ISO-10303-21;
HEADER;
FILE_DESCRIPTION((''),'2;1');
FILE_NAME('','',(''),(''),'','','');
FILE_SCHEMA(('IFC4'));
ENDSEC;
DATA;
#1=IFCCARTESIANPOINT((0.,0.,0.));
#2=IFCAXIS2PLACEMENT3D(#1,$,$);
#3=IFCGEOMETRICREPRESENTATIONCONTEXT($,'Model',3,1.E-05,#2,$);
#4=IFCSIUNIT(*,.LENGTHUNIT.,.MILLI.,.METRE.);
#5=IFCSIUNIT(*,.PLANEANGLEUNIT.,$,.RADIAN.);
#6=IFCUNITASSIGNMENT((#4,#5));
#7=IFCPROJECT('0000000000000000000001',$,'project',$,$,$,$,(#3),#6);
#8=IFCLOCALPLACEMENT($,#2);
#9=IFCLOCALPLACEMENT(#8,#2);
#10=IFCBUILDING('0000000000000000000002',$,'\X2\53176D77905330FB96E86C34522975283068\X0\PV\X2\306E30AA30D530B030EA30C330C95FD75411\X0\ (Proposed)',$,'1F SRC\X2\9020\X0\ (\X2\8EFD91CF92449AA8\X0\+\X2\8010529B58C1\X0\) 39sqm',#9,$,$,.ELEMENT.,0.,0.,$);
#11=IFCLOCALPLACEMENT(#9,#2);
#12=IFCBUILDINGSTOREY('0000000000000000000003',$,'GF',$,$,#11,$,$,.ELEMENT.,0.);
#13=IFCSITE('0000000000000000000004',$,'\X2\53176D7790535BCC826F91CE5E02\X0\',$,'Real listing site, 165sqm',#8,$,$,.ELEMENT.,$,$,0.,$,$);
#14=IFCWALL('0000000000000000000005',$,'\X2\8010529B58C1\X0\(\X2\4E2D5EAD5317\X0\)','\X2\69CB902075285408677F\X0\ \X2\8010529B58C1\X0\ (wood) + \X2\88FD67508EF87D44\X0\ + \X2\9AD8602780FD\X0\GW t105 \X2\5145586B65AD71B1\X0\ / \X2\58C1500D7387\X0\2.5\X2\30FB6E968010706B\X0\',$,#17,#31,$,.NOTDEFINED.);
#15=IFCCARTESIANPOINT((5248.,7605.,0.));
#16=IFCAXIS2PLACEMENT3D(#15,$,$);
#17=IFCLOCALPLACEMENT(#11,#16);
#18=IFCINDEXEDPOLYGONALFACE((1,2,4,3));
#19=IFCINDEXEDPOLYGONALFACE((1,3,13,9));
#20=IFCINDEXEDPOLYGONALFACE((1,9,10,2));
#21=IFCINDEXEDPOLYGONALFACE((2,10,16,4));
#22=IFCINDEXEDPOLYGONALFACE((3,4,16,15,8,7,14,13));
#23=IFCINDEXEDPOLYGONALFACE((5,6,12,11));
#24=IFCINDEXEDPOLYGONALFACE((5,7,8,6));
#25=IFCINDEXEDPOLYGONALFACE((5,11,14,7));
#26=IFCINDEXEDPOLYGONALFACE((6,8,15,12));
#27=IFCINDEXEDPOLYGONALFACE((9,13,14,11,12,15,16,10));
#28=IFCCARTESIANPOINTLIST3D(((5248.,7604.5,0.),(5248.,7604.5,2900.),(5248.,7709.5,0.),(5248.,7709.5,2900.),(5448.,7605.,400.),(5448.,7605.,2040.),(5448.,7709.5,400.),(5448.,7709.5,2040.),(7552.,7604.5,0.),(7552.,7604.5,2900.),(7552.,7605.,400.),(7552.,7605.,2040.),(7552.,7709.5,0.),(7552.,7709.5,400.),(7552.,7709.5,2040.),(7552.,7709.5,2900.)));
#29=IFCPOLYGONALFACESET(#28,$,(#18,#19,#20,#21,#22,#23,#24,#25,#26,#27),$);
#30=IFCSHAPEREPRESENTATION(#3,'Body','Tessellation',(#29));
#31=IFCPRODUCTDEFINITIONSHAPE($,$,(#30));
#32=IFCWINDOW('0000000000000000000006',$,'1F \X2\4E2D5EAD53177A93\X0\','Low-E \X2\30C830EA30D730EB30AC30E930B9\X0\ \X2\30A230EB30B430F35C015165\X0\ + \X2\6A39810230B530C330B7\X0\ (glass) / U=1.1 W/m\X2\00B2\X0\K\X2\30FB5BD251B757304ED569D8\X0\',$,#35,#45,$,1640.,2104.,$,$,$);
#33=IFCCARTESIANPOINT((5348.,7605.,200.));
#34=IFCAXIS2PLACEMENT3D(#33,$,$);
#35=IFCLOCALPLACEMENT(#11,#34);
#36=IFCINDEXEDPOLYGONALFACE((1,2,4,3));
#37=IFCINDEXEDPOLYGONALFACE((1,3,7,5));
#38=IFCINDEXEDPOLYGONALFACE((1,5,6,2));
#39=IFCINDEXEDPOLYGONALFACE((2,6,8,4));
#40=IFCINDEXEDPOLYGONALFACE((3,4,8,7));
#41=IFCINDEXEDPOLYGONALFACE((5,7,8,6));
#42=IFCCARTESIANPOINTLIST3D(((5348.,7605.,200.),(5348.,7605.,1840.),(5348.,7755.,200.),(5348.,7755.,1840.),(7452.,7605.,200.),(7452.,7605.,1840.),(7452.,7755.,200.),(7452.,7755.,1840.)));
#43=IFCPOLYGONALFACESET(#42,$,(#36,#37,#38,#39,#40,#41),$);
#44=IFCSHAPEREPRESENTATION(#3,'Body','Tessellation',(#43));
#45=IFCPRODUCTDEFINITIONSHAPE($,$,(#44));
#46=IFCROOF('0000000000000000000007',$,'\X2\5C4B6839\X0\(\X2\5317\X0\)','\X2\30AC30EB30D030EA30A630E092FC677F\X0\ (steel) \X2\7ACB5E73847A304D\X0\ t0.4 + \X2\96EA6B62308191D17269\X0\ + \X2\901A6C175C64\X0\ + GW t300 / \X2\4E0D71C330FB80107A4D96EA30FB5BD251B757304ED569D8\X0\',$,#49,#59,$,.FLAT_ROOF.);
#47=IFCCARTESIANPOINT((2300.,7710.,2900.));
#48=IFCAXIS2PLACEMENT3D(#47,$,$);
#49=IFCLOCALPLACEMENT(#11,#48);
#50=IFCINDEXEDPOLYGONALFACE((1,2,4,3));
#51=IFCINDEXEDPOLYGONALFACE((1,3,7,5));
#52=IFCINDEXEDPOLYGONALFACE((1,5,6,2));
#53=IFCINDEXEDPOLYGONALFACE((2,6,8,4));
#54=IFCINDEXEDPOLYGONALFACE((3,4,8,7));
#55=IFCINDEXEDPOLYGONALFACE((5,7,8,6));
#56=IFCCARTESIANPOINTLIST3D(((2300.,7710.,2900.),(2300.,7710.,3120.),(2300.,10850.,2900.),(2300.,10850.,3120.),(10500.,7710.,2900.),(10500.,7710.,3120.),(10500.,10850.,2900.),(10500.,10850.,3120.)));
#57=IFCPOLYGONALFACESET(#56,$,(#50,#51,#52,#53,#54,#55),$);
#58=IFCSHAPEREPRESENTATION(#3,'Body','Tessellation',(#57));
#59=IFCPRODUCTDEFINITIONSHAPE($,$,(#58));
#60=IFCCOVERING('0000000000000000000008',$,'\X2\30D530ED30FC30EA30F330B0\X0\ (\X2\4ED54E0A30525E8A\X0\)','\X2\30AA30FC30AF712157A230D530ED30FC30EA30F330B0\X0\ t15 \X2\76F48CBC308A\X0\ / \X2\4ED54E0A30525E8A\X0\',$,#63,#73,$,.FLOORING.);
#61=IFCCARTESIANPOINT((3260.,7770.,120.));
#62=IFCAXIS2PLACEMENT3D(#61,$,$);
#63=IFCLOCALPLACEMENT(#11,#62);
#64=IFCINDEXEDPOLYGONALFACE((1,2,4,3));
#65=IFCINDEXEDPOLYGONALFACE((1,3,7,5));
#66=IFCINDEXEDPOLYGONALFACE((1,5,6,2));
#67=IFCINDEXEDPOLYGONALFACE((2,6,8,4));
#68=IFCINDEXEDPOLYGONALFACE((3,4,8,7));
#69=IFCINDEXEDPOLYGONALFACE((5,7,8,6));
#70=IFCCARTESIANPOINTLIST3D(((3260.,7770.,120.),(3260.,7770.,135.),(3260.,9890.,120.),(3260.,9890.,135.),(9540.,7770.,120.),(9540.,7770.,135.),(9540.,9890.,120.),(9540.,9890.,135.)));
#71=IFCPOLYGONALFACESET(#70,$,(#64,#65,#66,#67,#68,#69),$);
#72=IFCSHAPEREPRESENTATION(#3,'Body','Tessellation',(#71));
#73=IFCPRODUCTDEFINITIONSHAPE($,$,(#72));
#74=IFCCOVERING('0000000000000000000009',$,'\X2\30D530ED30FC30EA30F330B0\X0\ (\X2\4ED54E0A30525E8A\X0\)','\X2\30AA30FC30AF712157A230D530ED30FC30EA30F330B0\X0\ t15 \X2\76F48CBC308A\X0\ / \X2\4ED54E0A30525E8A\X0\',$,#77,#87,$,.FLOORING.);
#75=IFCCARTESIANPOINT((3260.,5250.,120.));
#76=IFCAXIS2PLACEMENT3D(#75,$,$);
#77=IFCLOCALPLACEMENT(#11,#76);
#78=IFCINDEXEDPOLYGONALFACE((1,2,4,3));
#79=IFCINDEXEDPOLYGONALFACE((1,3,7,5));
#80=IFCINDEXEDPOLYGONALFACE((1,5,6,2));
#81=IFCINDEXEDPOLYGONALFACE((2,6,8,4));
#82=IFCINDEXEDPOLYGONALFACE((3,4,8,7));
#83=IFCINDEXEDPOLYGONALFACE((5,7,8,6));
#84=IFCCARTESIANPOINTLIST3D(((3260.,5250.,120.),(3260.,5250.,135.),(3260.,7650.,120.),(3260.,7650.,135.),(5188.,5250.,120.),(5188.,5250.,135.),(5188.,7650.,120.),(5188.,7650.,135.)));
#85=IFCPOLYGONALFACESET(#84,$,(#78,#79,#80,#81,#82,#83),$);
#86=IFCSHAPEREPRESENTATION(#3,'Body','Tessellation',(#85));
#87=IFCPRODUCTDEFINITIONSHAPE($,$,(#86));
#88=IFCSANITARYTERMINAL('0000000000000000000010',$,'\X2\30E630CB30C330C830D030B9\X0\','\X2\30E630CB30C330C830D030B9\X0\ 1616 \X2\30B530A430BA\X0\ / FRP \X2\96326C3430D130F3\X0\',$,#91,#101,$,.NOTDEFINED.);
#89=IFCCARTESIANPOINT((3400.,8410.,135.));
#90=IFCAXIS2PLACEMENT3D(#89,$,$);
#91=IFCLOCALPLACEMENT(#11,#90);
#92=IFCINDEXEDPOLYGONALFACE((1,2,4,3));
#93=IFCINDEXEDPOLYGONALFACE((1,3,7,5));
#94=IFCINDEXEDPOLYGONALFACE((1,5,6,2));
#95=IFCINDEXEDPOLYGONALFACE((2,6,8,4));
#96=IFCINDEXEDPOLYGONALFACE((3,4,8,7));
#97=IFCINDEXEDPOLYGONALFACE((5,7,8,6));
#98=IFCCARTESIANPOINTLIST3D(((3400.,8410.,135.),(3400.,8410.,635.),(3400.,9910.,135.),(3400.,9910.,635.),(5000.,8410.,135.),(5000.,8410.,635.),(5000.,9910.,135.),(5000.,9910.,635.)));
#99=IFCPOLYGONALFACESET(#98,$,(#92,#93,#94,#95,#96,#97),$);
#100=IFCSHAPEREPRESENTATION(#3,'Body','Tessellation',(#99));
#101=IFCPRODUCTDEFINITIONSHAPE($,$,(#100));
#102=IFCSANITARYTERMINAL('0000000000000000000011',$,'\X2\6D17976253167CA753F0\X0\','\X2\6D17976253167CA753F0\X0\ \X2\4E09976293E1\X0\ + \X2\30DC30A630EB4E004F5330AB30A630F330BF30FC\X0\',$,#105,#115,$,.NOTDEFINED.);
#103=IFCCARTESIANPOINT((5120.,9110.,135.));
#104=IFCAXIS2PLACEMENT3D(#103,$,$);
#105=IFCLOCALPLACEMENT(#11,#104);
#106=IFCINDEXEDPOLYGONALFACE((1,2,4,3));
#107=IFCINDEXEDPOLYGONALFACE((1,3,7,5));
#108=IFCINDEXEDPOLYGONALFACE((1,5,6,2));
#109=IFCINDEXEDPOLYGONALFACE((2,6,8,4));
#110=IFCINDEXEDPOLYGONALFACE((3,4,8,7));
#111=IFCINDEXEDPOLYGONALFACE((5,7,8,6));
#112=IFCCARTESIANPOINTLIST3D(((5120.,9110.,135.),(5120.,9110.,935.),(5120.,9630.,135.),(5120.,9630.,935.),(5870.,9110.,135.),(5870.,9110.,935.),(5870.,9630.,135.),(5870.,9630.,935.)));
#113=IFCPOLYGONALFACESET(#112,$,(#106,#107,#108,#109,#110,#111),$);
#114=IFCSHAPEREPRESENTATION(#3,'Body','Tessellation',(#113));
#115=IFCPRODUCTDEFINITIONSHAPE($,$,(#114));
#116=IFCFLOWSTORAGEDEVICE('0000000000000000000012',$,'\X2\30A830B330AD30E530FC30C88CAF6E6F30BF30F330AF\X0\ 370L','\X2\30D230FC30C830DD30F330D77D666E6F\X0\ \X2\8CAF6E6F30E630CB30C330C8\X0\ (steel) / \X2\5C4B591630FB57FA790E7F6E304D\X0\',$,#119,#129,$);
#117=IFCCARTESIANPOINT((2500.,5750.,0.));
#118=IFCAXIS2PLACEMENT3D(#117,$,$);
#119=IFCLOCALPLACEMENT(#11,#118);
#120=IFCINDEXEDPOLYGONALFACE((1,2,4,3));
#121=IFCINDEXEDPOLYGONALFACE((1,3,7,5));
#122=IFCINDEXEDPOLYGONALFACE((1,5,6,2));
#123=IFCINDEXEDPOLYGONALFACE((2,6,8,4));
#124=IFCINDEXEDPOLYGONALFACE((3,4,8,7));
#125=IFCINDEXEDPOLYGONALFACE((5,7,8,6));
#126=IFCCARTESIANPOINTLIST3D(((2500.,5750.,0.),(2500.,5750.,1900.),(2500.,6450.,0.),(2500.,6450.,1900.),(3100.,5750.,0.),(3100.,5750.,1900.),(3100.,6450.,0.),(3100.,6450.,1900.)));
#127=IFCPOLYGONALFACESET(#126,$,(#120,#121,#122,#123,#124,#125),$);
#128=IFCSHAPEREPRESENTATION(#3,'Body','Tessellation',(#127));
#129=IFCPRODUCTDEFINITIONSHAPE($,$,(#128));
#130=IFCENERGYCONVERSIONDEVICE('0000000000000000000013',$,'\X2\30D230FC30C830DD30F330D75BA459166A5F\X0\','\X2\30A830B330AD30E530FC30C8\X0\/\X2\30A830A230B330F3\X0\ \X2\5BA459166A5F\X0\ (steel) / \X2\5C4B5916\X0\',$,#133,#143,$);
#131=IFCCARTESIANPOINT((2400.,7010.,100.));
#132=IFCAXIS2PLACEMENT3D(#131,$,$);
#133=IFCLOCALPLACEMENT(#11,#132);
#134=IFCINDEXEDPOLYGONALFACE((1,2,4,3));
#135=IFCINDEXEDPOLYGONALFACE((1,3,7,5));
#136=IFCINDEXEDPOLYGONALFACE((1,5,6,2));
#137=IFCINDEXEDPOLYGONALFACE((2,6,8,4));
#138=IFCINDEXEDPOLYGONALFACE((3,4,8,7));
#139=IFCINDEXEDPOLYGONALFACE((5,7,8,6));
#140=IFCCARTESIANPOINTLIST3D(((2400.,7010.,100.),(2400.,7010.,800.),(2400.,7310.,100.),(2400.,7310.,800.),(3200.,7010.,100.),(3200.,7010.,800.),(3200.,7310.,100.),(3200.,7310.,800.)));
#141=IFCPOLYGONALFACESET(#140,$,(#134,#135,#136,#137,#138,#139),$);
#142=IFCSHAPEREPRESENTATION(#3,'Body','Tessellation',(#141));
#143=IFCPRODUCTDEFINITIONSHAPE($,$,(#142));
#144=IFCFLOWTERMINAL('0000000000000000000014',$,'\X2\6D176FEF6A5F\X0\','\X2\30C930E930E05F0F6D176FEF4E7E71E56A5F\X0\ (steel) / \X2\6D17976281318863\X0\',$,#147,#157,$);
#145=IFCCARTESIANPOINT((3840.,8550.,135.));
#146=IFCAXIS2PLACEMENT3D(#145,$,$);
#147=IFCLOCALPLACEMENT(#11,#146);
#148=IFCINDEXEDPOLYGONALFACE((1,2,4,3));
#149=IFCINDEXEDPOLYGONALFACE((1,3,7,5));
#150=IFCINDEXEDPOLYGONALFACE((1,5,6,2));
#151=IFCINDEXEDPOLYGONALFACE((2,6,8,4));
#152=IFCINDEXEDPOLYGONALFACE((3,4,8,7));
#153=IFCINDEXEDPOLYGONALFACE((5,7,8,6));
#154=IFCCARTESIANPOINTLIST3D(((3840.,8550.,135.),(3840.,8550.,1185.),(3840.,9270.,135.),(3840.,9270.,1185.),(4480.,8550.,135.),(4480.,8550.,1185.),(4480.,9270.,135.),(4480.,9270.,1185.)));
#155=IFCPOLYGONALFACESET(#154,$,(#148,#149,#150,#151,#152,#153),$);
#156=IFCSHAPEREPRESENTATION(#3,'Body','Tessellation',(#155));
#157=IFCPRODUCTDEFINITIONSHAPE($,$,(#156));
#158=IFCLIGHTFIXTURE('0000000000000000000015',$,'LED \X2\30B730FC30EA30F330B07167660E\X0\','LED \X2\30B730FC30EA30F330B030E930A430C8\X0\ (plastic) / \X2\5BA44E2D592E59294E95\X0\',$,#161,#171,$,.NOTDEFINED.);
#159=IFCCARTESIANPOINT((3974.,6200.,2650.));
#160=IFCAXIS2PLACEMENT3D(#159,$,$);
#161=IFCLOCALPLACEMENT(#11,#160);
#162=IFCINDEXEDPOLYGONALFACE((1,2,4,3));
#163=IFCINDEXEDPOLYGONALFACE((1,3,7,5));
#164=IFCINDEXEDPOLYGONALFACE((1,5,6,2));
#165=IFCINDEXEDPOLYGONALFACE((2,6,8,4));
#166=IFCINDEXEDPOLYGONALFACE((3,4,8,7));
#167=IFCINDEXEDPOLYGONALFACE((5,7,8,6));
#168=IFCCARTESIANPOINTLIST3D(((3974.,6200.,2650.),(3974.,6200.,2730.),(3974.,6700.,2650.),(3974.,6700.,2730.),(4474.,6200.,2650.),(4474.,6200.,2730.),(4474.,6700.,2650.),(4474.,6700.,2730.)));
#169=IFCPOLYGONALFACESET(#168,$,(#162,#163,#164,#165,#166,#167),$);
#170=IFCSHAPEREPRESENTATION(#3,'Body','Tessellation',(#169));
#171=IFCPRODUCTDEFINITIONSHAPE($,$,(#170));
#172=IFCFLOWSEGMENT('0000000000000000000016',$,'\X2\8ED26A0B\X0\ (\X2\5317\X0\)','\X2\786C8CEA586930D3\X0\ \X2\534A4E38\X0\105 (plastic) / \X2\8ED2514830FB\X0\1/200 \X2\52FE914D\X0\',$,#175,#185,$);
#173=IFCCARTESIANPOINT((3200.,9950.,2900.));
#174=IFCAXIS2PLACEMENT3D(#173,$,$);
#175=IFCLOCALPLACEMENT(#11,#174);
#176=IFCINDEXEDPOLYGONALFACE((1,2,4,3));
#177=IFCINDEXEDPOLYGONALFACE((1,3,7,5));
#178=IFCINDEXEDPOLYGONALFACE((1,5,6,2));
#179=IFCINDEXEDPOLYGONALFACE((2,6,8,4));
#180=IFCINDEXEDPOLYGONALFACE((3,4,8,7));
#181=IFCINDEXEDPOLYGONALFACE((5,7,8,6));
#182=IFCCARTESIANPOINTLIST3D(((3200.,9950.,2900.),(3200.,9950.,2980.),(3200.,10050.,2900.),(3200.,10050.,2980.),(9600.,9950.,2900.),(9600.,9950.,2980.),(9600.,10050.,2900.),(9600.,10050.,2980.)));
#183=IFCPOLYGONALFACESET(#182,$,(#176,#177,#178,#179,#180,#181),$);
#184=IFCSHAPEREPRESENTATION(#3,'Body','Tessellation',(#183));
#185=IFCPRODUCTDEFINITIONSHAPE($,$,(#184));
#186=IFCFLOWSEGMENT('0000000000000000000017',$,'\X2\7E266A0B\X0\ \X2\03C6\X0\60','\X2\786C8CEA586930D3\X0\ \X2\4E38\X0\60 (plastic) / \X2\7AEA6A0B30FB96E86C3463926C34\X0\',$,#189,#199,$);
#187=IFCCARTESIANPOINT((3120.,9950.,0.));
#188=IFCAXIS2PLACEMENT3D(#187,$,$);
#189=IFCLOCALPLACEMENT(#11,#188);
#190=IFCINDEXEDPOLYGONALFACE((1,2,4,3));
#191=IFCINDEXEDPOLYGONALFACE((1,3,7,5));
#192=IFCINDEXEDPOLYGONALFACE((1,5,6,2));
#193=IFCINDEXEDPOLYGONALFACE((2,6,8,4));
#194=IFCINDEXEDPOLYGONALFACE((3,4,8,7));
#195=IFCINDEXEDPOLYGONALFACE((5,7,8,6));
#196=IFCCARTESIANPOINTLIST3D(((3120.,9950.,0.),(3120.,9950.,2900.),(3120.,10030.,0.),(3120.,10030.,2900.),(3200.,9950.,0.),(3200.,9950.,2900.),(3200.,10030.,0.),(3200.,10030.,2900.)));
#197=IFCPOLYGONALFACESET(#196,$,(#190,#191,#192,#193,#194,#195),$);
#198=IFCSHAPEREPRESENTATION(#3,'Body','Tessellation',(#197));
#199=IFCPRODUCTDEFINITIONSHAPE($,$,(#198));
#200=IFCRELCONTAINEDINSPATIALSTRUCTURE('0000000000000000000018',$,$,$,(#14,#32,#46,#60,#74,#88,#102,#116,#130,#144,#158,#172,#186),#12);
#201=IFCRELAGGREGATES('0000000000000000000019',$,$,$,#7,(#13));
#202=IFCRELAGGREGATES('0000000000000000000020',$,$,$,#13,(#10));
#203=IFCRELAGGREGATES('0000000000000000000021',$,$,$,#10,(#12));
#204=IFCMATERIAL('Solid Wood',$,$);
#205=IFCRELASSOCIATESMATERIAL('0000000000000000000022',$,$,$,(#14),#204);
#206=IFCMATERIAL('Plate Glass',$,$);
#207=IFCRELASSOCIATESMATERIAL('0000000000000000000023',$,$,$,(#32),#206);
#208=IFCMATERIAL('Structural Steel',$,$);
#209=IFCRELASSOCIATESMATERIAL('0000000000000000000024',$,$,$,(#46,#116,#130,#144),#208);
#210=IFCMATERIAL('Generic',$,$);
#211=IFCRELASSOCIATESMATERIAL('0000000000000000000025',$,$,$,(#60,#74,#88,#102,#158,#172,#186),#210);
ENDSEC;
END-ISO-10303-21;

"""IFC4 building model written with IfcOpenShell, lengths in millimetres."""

from ifc_helpers import new_model, si_unit, frame, frame_2d, origin, place, context, project, spatial, rectangle, extrude, material, element, fill, save


model = new_model("IFC4")

# Units and contexts
model_context = context("Model", 3, precision=1e-05, world=origin())
ifc_project = project(units=[si_unit("LENGTHUNIT", "METRE", prefix="MILLI"), si_unit("PLANEANGLEUNIT", "RADIAN")], contexts=[model_context])

# Site, building, storey
site_placement = place(None, origin())
site = spatial("IfcSite", under=ifc_project, at=site_placement, Name="北海道富良野市", ObjectType="Real listing site, 165sqm", CompositionType="ELEMENT", RefElevation=0.0)
building_placement = place(site_placement, origin())
building = spatial("IfcBuilding", under=site, at=building_placement, Name="北海道・雨水利用とPVのオフグリッド志向 (Proposed)", ObjectType="1F SRC造 (軽量鉄骨+耐力壁) 39sqm", CompositionType="ELEMENT", ElevationOfRefHeight=0.0, ElevationOfTerrain=0.0)
storey_placement = place(building_placement, origin())
storey = spatial("IfcBuildingStorey", under=building, at=storey_placement, Name="GF", CompositionType="ELEMENT", Elevation=0.0)

# Shared definitions
ifc_material_1 = material(Name="Solid Wood")

# Shared definitions
ifc_material_2 = material(Name="Plate Glass")

# Wall, opening, window
wall_1_placement = place(storey_placement, frame((5248.0, 7605.0, 0.0)))
wall_1 = element("IfcWall", 1, at=wall_1_placement, inside=storey, material=ifc_material_1, Name="耐力壁(中庭北)", Description="構造用合板 耐力壁 (wood) + 製材軸組 + 高性能GW t105 充填断熱 / 壁倍率2.5・準耐火", PredefinedType="NOTDEFINED", context=model_context, shape_type="SweptSolid", body=[
    extrude(rectangle(XDim=2304.0, YDim=105.0, at=frame_2d((1152.0, 52.0))), frame((5248.0, 7605.0, 0.0)), (0.0, 0.0, 1.0), 2900.0),
])
opening_1_placement = place(storey_placement, frame((5348.0, 7605.0, 200.0)))
opening_1 = element("IfcOpeningElement", 2, at=opening_1_placement, cuts=wall_1, PredefinedType="NOTDEFINED", context=model_context, shape_type="SweptSolid", body=[
    extrude(rectangle(XDim=2104.0, YDim=150.0, at=frame_2d((1052.0, 75.0))), frame((5348.0, 7605.0, 200.0)), (0.0, 0.0, 1.0), 1640.0),
])
window_1_placement = place(storey_placement, frame((5348.0, 7605.0, 200.0)))
window_1 = element("IfcWindow", 3, at=window_1_placement, inside=storey, material=ifc_material_2, Name="1F 中庭北窓", Description="Low-E トリプルガラス アルゴン封入 + 樹脂サッシ (glass) / U=1.1 W/m²K・寒冷地仕様", OverallHeight=1640.0, OverallWidth=2104.0, context=model_context, shape_type="SweptSolid", body=[
    extrude(rectangle(XDim=2104.0, YDim=150.0, at=frame_2d((1052.0, 75.0))), frame((5348.0, 7605.0, 200.0)), (0.0, 0.0, 1.0), 1640.0),
])
fill(opening_1, window_1)

# Roof
ifc_material_3 = material(Name="Structural Steel")
roof_placement = place(storey_placement, frame((2300.0, 7710.0, 2900.0)))
element("IfcRoof", 4, at=roof_placement, inside=storey, material=ifc_material_3, Name="屋根(北)", Description="ガルバリウム鋼板 (steel) 立平葺き t0.4 + 雪止め金物 + 通気層 + GW t300 / 不燃・耐積雪・寒冷地仕様", PredefinedType="FLAT_ROOF", context=model_context, shape_type="SweptSolid", body=[
    extrude(rectangle(XDim=8200.0, YDim=3140.0, at=frame_2d((4100.0, 1570.0))), frame((2300.0, 7710.0, 2900.0)), (0.0, 0.0, 1.0), 220.0),
])

# Coverings
ifc_material_4 = material(Name="Generic")
covering_1_placement = place(storey_placement, frame((3260.0, 7770.0, 120.0)))
element("IfcCovering", 5, at=covering_1_placement, inside=storey, material=ifc_material_4, Name="フローリング (仕上げ床)", Description="オーク無垢フローリング t15 直貼り / 仕上げ床", PredefinedType="FLOORING", context=model_context, shape_type="SweptSolid", body=[
    extrude(rectangle(XDim=6280.0, YDim=2120.0, at=frame_2d((3140.0, 1060.0))), frame((3260.0, 7770.0, 120.0)), (0.0, 0.0, 1.0), 15.0),
])
covering_2_placement = place(storey_placement, frame((3260.0, 5250.0, 120.0)))
element("IfcCovering", 6, at=covering_2_placement, inside=storey, material=ifc_material_4, Name="フローリング (仕上げ床)", Description="オーク無垢フローリング t15 直貼り / 仕上げ床", PredefinedType="FLOORING", context=model_context, shape_type="SweptSolid", body=[
    extrude(rectangle(XDim=1928.0, YDim=2400.0, at=frame_2d((964.0, 1200.0))), frame((3260.0, 5250.0, 120.0)), (0.0, 0.0, 1.0), 15.0),
])

# Sanitary terminals
sanitary_terminal_1_placement = place(storey_placement, frame((3400.0, 8410.0, 135.0)))
element("IfcSanitaryTerminal", 7, at=sanitary_terminal_1_placement, inside=storey, material=ifc_material_4, Name="ユニットバス", Description="ユニットバス 1616 サイズ / FRP 防水パン", PredefinedType="NOTDEFINED", context=model_context, shape_type="SweptSolid", body=[
    extrude(rectangle(XDim=1600.0, YDim=1500.0, at=frame_2d((800.0, 750.0))), frame((3400.0, 8410.0, 135.0)), (0.0, 0.0, 1.0), 500.0),
])
sanitary_terminal_2_placement = place(storey_placement, frame((5120.0, 9110.0, 135.0)))
element("IfcSanitaryTerminal", 8, at=sanitary_terminal_2_placement, inside=storey, material=ifc_material_4, Name="洗面化粧台", Description="洗面化粧台 三面鏡 + ボウル一体カウンター", PredefinedType="NOTDEFINED", context=model_context, shape_type="SweptSolid", body=[
    extrude(rectangle(XDim=750.0, YDim=520.0, at=frame_2d((375.0, 260.0))), frame((5120.0, 9110.0, 135.0)), (0.0, 0.0, 1.0), 800.0),
])

# Flow storage device
flow_storage_device_placement = place(storey_placement, frame((2500.0, 5750.0, 0.0)))
element("IfcFlowStorageDevice", 9, at=flow_storage_device_placement, inside=storey, material=ifc_material_3, Name="エコキュート貯湯タンク 370L", Description="ヒートポンプ給湯 貯湯ユニット (steel) / 屋外・基礎置き", context=model_context, shape_type="SweptSolid", body=[
    extrude(rectangle(XDim=600.0, YDim=700.0, at=frame_2d((300.0, 350.0))), frame((2500.0, 5750.0, 0.0)), (0.0, 0.0, 1.0), 1900.0),
])

# Energy conversion device
energy_conversion_device_placement = place(storey_placement, frame((2400.0, 7010.0, 100.0)))
element("IfcEnergyConversionDevice", 10, at=energy_conversion_device_placement, inside=storey, material=ifc_material_3, Name="ヒートポンプ室外機", Description="エコキュート/エアコン 室外機 (steel) / 屋外", context=model_context, shape_type="SweptSolid", body=[
    extrude(rectangle(XDim=800.0, YDim=300.0, at=frame_2d((400.0, 150.0))), frame((2400.0, 7010.0, 100.0)), (0.0, 0.0, 1.0), 700.0),
])

# Flow terminal
flow_terminal_placement = place(storey_placement, frame((3840.0, 8550.0, 135.0)))
element("IfcFlowTerminal", 11, at=flow_terminal_placement, inside=storey, material=ifc_material_3, Name="洗濯機", Description="ドラム式洗濯乾燥機 (steel) / 洗面脱衣", context=model_context, shape_type="SweptSolid", body=[
    extrude(rectangle(XDim=640.0, YDim=720.0, at=frame_2d((320.0, 360.0))), frame((3840.0, 8550.0, 135.0)), (0.0, 0.0, 1.0), 1050.0),
])

# Light fixture
light_fixture_placement = place(storey_placement, frame((3974.0, 6200.0, 2650.0)))
element("IfcLightFixture", 12, at=light_fixture_placement, inside=storey, material=ifc_material_4, Name="LED シーリング照明", Description="LED シーリングライト (plastic) / 室中央天井", PredefinedType="NOTDEFINED", context=model_context, shape_type="SweptSolid", body=[
    extrude(rectangle(XDim=500.0, YDim=500.0, at=frame_2d((250.0, 250.0))), frame((3974.0, 6200.0, 2650.0)), (0.0, 0.0, 1.0), 80.0),
])

# Flow segments
flow_segment_1_placement = place(storey_placement, frame((3200.0, 9950.0, 2900.0)))
element("IfcFlowSegment", 13, at=flow_segment_1_placement, inside=storey, material=ifc_material_4, Name="軒樋 (北)", Description="硬質塩ビ 半丸105 (plastic) / 軒先・1/200 勾配", context=model_context, shape_type="SweptSolid", body=[
    extrude(rectangle(XDim=6400.0, YDim=100.0, at=frame_2d((3200.0, 50.0))), frame((3200.0, 9950.0, 2900.0)), (0.0, 0.0, 1.0), 80.0),
])
flow_segment_2_placement = place(storey_placement, frame((3120.0, 9950.0, 0.0)))
element("IfcFlowSegment", 14, at=flow_segment_2_placement, inside=storey, material=ifc_material_4, Name="縦樋 φ60", Description="硬質塩ビ 丸60 (plastic) / 竪樋・雨水排水", context=model_context, shape_type="SweptSolid", body=[
    extrude(rectangle(XDim=80.0, YDim=80.0, at=frame_2d((40.0, 40.0))), frame((3120.0, 9950.0, 0.0)), (0.0, 0.0, 1.0), 2900.0),
])

save(model, "model.ifc")
